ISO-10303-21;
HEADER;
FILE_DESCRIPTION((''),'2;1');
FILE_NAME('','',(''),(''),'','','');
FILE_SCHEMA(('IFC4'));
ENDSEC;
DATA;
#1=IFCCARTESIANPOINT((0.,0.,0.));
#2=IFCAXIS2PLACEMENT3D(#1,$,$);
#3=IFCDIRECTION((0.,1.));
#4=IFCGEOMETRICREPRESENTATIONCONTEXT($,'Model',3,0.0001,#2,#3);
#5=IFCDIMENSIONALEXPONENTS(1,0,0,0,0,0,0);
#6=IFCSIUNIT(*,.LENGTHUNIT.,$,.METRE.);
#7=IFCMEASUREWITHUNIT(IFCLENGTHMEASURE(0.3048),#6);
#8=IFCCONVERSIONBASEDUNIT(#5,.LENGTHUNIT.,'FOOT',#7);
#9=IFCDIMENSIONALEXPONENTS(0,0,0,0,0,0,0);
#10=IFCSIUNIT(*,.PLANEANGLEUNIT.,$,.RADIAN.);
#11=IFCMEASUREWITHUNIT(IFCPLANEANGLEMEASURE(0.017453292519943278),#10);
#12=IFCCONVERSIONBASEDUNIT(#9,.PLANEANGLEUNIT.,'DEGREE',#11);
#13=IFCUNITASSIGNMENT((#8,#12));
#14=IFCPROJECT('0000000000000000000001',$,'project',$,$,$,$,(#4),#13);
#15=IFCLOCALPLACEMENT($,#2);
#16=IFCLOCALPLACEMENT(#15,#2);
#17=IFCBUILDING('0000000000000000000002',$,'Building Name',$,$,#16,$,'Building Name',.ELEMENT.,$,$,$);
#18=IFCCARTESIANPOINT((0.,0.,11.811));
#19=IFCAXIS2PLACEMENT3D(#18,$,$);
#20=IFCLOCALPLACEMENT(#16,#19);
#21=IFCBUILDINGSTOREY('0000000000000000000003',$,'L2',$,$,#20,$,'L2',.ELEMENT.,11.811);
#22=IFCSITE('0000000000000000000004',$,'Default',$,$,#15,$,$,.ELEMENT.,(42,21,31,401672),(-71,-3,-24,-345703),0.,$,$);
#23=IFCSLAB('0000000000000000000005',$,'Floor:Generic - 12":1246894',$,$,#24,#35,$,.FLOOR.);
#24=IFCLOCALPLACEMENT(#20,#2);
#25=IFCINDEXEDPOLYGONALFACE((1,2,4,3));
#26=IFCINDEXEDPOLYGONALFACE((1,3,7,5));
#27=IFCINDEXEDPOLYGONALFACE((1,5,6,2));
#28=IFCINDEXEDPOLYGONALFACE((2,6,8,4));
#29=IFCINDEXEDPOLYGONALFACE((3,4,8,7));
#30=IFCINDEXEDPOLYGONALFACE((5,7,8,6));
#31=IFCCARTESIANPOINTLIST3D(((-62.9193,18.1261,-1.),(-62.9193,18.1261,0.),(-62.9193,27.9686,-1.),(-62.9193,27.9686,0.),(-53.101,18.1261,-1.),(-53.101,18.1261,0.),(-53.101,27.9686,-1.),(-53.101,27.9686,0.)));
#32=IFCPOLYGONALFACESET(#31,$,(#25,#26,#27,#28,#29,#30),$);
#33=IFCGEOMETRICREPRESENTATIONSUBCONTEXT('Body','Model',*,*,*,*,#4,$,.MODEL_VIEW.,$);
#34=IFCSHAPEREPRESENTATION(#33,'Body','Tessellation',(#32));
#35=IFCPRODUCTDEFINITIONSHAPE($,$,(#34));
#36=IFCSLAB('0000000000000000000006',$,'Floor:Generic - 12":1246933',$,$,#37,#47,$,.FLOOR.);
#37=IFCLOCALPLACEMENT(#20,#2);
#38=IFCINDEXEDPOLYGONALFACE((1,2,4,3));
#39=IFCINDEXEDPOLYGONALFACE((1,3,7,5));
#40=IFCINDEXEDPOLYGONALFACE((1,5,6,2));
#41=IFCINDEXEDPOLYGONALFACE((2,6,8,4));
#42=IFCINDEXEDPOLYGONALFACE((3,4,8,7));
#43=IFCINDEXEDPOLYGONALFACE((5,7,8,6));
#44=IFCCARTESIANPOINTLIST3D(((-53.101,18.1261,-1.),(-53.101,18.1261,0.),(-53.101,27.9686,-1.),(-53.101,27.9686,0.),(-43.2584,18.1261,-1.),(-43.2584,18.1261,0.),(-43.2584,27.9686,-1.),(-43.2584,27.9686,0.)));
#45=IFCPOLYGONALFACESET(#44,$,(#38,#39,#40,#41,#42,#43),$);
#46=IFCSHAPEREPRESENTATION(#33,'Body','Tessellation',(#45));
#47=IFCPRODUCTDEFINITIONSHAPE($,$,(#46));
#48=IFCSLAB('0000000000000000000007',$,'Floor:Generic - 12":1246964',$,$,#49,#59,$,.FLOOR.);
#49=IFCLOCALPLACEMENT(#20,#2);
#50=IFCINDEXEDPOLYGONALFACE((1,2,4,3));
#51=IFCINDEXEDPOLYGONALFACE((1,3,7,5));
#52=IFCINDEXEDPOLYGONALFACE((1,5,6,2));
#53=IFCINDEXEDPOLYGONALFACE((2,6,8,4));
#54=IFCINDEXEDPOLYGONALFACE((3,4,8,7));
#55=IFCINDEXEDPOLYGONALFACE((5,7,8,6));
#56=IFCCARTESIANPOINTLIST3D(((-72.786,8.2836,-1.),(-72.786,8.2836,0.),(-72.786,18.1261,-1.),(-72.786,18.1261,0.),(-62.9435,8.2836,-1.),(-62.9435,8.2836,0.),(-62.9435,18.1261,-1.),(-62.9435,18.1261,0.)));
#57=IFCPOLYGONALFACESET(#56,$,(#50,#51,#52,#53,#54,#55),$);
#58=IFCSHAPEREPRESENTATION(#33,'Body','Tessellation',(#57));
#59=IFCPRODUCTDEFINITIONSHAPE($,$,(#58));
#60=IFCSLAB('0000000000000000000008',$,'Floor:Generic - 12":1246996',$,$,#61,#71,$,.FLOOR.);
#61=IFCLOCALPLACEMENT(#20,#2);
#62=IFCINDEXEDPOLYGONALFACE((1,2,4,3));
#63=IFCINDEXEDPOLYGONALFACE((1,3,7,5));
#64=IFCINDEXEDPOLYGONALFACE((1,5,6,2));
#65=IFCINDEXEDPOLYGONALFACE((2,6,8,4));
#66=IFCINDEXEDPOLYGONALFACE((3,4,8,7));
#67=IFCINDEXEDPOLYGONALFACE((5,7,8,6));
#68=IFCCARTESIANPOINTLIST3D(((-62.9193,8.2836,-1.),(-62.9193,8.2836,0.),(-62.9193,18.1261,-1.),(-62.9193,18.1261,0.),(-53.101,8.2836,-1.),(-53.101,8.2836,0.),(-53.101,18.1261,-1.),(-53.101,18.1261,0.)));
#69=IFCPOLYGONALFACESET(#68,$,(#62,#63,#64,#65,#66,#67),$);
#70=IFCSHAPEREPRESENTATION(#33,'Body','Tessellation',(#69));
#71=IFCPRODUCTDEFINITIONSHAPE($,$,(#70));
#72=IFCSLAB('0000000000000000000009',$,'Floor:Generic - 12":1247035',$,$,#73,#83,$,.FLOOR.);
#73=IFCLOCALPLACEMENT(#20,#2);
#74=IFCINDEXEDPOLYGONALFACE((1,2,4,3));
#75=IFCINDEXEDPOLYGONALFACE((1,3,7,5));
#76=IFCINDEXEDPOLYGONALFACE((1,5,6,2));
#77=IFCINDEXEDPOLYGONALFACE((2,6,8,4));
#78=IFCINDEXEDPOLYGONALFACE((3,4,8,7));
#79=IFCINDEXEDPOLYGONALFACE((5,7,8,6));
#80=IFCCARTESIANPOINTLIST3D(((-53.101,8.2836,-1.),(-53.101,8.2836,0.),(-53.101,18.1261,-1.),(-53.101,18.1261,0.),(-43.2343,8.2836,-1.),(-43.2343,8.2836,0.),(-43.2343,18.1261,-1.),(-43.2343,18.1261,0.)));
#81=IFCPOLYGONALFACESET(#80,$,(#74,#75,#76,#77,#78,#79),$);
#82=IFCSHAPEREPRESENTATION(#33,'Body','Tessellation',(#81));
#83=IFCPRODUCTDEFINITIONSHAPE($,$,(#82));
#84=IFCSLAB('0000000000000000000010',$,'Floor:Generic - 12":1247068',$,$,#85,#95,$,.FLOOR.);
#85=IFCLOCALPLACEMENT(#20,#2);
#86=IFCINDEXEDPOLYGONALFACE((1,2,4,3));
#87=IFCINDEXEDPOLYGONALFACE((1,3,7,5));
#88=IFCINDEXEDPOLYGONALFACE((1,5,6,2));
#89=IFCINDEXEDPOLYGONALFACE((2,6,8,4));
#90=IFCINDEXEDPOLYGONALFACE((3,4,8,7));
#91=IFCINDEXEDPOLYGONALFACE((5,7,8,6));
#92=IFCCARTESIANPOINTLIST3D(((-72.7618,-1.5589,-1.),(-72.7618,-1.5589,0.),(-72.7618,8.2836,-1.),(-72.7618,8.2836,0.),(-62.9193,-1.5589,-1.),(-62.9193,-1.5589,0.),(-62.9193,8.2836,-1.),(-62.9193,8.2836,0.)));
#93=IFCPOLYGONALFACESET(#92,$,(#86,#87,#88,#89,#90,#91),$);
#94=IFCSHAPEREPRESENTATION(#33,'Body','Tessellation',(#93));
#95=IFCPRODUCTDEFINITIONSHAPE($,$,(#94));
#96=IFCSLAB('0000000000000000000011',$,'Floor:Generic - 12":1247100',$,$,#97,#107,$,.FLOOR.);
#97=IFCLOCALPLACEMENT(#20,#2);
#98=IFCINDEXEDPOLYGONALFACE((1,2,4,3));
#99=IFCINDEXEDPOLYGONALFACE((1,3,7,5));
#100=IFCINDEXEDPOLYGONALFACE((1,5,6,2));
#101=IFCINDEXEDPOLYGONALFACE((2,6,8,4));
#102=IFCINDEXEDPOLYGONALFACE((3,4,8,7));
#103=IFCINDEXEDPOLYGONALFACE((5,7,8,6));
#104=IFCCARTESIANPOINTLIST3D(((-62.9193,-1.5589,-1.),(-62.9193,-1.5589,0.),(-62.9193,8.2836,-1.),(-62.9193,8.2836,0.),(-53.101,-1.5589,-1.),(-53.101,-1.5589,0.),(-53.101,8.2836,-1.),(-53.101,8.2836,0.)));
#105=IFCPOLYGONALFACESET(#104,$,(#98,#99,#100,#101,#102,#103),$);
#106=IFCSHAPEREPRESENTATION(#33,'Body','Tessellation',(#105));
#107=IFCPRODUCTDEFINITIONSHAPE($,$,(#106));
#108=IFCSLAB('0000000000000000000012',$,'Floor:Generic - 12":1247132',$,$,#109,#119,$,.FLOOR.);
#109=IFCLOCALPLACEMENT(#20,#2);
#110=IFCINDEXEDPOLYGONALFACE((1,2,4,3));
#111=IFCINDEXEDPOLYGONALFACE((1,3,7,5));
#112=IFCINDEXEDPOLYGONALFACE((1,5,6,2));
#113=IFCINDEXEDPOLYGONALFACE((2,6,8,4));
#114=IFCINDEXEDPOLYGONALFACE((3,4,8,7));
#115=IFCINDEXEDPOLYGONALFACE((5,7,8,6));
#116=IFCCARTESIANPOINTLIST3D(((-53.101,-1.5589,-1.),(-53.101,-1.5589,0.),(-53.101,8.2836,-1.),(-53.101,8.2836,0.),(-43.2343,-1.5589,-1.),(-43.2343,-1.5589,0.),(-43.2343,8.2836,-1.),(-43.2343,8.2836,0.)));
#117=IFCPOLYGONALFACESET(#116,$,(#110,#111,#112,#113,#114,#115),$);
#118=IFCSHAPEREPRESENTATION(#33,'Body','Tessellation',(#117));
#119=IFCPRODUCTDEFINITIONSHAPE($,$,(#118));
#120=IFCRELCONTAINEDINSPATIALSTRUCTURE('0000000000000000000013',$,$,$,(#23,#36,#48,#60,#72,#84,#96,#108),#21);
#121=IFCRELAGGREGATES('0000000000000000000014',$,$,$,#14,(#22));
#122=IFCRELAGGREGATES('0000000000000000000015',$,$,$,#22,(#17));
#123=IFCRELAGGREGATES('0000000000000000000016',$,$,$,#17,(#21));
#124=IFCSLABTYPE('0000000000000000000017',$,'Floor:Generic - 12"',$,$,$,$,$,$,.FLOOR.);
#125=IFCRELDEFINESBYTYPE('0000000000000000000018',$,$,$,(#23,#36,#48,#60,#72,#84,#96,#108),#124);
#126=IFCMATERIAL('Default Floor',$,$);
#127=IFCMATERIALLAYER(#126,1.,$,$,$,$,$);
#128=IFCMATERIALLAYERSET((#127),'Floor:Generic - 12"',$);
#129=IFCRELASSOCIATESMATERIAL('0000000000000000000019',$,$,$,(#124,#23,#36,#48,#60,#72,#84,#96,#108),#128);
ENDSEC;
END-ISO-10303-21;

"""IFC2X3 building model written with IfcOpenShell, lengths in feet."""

from ifc_helpers import new_model, entity, si_unit, converted_unit, direction, frame, frame_2d, origin, origin_2d_with_axis, place, context, subcontext, project, spatial, rectangle, extrude, material, layer, layer_set, layer_usage, type_object, element, save


model = new_model("IFC2X3")

# Units and contexts
model_context = context("Model", 3, precision=0.0001, world=origin(), true_north=direction((0.0, 1.0)))
body_context = subcontext(model_context, "Body", "Model", "MODEL_VIEW")
ifc_project = project(units=[converted_unit("LENGTHUNIT", "FOOT", entity("IfcLengthMeasure", 0.3048), si_unit("LENGTHUNIT", "METRE"), dimensions=[1, 0, 0, 0, 0, 0, 0]), converted_unit("PLANEANGLEUNIT", "DEGREE", entity("IfcPlaneAngleMeasure", 0.017453292519943278), si_unit("PLANEANGLEUNIT", "RADIAN"), dimensions=[0, 0, 0, 0, 0, 0, 0])], contexts=[model_context])

# Site, building, storey
site_placement = place(None, origin())
site = spatial("IfcSite", under=ifc_project, at=site_placement, Name="Default", CompositionType="ELEMENT", RefLatitude=(42, 21, 31, 401672), RefLongitude=(-71, -3, -24, -345703), RefElevation=0.0)
building_placement = place(site_placement, origin())
building = spatial("IfcBuilding", under=site, at=building_placement, Name="Building Name", LongName="Building Name", CompositionType="ELEMENT")
storey_placement = place(building_placement, frame((0.0, 0.0, 11.811)))
storey = spatial("IfcBuildingStorey", under=building, at=storey_placement, Name="L2", LongName="L2", CompositionType="ELEMENT", Elevation=11.811)

# Slabs
ifc_material_1 = material(Name="Default Floor")
ifc_layer = layer(ifc_material_1, 1.0)
ifc_layer_set = layer_set([ifc_layer], Name="Floor:Generic - 12\"")
slab_type = type_object("IfcSlabType", Name="Floor:Generic - 12\"", PredefinedType="FLOOR", material=ifc_layer_set)
ifc_layer_usage_1 = layer_usage(ifc_layer_set, "AXIS3", "POSITIVE", 0.0)
slab_1_placement = place(storey_placement, origin())
element("IfcSlab", 1, at=slab_1_placement, inside=storey, type_object=slab_type, material=ifc_layer_usage_1, Name="Floor:Generic - 12\":1246894", PredefinedType="FLOOR", context=body_context, shape_type="SweptSolid", body=[
    extrude(rectangle(XDim=9.8425, YDim=9.8184, at=origin_2d_with_axis()), frame((-58.0101, 23.0474, 0.0), z_axis=(0.0, 0.0, -1.0), x_axis=(0.0, 1.0, 0.0)), (0.0, 0.0, 1.0), 1.0),
])
ifc_layer_usage_2 = layer_usage(ifc_layer_set, "AXIS3", "POSITIVE", 0.0)
slab_2_placement = place(storey_placement, origin())
element("IfcSlab", 2, at=slab_2_placement, inside=storey, type_object=slab_type, material=ifc_layer_usage_2, Name="Floor:Generic - 12\":1246933", PredefinedType="FLOOR", context=body_context, shape_type="SweptSolid", body=[
    extrude(rectangle(XDim=9.8425, YDim=9.8425, at=frame_2d((0.0, 0.0), x_axis=(1.0, 0.0))), frame((-48.1797, 23.0474, 0.0), z_axis=(0.0, 0.0, -1.0), x_axis=(0.0, 1.0, 0.0)), (0.0, 0.0, 1.0), 1.0),
])
ifc_layer_usage_3 = layer_usage(ifc_layer_set, "AXIS3", "POSITIVE", 0.0)
slab_3_placement = place(storey_placement, origin())
element("IfcSlab", 3, at=slab_3_placement, inside=storey, type_object=slab_type, material=ifc_layer_usage_3, Name="Floor:Generic - 12\":1246964", PredefinedType="FLOOR", context=body_context, shape_type="SweptSolid", body=[
    extrude(rectangle(XDim=9.8425, YDim=9.8425, at=frame_2d((0.0, 0.0), x_axis=(1.0, 0.0))), frame((-67.8647, 13.2049, 0.0), z_axis=(0.0, 0.0, -1.0), x_axis=(0.0, 1.0, 0.0)), (0.0, 0.0, 1.0), 1.0),
])
ifc_layer_usage_4 = layer_usage(ifc_layer_set, "AXIS3", "POSITIVE", 0.0)
slab_4_placement = place(storey_placement, origin())
element("IfcSlab", 4, at=slab_4_placement, inside=storey, type_object=slab_type, material=ifc_layer_usage_4, Name="Floor:Generic - 12\":1246996", PredefinedType="FLOOR", context=body_context, shape_type="SweptSolid", body=[
    extrude(rectangle(XDim=9.8425, YDim=9.8184, at=frame_2d((0.0, 0.0), x_axis=(1.0, 0.0))), frame((-58.0101, 13.2049, 0.0), z_axis=(0.0, 0.0, -1.0), x_axis=(0.0, 1.0, 0.0)), (0.0, 0.0, 1.0), 1.0),
])
ifc_layer_usage_5 = layer_usage(ifc_layer_set, "AXIS3", "POSITIVE", 0.0)
slab_5_placement = place(storey_placement, origin())
element("IfcSlab", 5, at=slab_5_placement, inside=storey, type_object=slab_type, material=ifc_layer_usage_5, Name="Floor:Generic - 12\":1247035", PredefinedType="FLOOR", context=body_context, shape_type="SweptSolid", body=[
    extrude(rectangle(XDim=9.8425, YDim=9.8667, at=frame_2d((0.0, 0.0), x_axis=(1.0, 0.0))), frame((-48.1676, 13.2049, 0.0), z_axis=(0.0, 0.0, -1.0), x_axis=(0.0, 1.0, 0.0)), (0.0, 0.0, 1.0), 1.0),
])
ifc_layer_usage_6 = layer_usage(ifc_layer_set, "AXIS3", "POSITIVE", 0.0)
slab_6_placement = place(storey_placement, origin())
element("IfcSlab", 6, at=slab_6_placement, inside=storey, type_object=slab_type, material=ifc_layer_usage_6, Name="Floor:Generic - 12\":1247068", PredefinedType="FLOOR", context=body_context, shape_type="SweptSolid", body=[
    extrude(rectangle(XDim=9.8425, YDim=9.8425, at=origin_2d_with_axis()), frame((-67.8406, 3.3623, 0.0), z_axis=(0.0, 0.0, -1.0), x_axis=(0.0, 1.0, 0.0)), (0.0, 0.0, 1.0), 1.0),
])
ifc_layer_usage_7 = layer_usage(ifc_layer_set, "AXIS3", "POSITIVE", 0.0)
slab_7_placement = place(storey_placement, origin())
element("IfcSlab", 7, at=slab_7_placement, inside=storey, type_object=slab_type, material=ifc_layer_usage_7, Name="Floor:Generic - 12\":1247100", PredefinedType="FLOOR", context=body_context, shape_type="SweptSolid", body=[
    extrude(rectangle(XDim=9.8425, YDim=9.8184, at=origin_2d_with_axis()), frame((-58.0101, 3.3623, 0.0), z_axis=(0.0, 0.0, -1.0), x_axis=(0.0, 1.0, 0.0)), (0.0, 0.0, 1.0), 1.0),
])
ifc_layer_usage_8 = layer_usage(ifc_layer_set, "AXIS3", "POSITIVE", 0.0)
slab_8_placement = place(storey_placement, origin())
element("IfcSlab", 8, at=slab_8_placement, inside=storey, type_object=slab_type, material=ifc_layer_usage_8, Name="Floor:Generic - 12\":1247132", PredefinedType="FLOOR", context=body_context, shape_type="SweptSolid", body=[
    extrude(rectangle(XDim=9.8425, YDim=9.8667, at=origin_2d_with_axis()), frame((-48.1676, 3.3623, 0.0), z_axis=(0.0, 0.0, -1.0), x_axis=(0.0, 1.0, 0.0)), (0.0, 0.0, 1.0), 1.0),
])

save(model, "model.ifc")
